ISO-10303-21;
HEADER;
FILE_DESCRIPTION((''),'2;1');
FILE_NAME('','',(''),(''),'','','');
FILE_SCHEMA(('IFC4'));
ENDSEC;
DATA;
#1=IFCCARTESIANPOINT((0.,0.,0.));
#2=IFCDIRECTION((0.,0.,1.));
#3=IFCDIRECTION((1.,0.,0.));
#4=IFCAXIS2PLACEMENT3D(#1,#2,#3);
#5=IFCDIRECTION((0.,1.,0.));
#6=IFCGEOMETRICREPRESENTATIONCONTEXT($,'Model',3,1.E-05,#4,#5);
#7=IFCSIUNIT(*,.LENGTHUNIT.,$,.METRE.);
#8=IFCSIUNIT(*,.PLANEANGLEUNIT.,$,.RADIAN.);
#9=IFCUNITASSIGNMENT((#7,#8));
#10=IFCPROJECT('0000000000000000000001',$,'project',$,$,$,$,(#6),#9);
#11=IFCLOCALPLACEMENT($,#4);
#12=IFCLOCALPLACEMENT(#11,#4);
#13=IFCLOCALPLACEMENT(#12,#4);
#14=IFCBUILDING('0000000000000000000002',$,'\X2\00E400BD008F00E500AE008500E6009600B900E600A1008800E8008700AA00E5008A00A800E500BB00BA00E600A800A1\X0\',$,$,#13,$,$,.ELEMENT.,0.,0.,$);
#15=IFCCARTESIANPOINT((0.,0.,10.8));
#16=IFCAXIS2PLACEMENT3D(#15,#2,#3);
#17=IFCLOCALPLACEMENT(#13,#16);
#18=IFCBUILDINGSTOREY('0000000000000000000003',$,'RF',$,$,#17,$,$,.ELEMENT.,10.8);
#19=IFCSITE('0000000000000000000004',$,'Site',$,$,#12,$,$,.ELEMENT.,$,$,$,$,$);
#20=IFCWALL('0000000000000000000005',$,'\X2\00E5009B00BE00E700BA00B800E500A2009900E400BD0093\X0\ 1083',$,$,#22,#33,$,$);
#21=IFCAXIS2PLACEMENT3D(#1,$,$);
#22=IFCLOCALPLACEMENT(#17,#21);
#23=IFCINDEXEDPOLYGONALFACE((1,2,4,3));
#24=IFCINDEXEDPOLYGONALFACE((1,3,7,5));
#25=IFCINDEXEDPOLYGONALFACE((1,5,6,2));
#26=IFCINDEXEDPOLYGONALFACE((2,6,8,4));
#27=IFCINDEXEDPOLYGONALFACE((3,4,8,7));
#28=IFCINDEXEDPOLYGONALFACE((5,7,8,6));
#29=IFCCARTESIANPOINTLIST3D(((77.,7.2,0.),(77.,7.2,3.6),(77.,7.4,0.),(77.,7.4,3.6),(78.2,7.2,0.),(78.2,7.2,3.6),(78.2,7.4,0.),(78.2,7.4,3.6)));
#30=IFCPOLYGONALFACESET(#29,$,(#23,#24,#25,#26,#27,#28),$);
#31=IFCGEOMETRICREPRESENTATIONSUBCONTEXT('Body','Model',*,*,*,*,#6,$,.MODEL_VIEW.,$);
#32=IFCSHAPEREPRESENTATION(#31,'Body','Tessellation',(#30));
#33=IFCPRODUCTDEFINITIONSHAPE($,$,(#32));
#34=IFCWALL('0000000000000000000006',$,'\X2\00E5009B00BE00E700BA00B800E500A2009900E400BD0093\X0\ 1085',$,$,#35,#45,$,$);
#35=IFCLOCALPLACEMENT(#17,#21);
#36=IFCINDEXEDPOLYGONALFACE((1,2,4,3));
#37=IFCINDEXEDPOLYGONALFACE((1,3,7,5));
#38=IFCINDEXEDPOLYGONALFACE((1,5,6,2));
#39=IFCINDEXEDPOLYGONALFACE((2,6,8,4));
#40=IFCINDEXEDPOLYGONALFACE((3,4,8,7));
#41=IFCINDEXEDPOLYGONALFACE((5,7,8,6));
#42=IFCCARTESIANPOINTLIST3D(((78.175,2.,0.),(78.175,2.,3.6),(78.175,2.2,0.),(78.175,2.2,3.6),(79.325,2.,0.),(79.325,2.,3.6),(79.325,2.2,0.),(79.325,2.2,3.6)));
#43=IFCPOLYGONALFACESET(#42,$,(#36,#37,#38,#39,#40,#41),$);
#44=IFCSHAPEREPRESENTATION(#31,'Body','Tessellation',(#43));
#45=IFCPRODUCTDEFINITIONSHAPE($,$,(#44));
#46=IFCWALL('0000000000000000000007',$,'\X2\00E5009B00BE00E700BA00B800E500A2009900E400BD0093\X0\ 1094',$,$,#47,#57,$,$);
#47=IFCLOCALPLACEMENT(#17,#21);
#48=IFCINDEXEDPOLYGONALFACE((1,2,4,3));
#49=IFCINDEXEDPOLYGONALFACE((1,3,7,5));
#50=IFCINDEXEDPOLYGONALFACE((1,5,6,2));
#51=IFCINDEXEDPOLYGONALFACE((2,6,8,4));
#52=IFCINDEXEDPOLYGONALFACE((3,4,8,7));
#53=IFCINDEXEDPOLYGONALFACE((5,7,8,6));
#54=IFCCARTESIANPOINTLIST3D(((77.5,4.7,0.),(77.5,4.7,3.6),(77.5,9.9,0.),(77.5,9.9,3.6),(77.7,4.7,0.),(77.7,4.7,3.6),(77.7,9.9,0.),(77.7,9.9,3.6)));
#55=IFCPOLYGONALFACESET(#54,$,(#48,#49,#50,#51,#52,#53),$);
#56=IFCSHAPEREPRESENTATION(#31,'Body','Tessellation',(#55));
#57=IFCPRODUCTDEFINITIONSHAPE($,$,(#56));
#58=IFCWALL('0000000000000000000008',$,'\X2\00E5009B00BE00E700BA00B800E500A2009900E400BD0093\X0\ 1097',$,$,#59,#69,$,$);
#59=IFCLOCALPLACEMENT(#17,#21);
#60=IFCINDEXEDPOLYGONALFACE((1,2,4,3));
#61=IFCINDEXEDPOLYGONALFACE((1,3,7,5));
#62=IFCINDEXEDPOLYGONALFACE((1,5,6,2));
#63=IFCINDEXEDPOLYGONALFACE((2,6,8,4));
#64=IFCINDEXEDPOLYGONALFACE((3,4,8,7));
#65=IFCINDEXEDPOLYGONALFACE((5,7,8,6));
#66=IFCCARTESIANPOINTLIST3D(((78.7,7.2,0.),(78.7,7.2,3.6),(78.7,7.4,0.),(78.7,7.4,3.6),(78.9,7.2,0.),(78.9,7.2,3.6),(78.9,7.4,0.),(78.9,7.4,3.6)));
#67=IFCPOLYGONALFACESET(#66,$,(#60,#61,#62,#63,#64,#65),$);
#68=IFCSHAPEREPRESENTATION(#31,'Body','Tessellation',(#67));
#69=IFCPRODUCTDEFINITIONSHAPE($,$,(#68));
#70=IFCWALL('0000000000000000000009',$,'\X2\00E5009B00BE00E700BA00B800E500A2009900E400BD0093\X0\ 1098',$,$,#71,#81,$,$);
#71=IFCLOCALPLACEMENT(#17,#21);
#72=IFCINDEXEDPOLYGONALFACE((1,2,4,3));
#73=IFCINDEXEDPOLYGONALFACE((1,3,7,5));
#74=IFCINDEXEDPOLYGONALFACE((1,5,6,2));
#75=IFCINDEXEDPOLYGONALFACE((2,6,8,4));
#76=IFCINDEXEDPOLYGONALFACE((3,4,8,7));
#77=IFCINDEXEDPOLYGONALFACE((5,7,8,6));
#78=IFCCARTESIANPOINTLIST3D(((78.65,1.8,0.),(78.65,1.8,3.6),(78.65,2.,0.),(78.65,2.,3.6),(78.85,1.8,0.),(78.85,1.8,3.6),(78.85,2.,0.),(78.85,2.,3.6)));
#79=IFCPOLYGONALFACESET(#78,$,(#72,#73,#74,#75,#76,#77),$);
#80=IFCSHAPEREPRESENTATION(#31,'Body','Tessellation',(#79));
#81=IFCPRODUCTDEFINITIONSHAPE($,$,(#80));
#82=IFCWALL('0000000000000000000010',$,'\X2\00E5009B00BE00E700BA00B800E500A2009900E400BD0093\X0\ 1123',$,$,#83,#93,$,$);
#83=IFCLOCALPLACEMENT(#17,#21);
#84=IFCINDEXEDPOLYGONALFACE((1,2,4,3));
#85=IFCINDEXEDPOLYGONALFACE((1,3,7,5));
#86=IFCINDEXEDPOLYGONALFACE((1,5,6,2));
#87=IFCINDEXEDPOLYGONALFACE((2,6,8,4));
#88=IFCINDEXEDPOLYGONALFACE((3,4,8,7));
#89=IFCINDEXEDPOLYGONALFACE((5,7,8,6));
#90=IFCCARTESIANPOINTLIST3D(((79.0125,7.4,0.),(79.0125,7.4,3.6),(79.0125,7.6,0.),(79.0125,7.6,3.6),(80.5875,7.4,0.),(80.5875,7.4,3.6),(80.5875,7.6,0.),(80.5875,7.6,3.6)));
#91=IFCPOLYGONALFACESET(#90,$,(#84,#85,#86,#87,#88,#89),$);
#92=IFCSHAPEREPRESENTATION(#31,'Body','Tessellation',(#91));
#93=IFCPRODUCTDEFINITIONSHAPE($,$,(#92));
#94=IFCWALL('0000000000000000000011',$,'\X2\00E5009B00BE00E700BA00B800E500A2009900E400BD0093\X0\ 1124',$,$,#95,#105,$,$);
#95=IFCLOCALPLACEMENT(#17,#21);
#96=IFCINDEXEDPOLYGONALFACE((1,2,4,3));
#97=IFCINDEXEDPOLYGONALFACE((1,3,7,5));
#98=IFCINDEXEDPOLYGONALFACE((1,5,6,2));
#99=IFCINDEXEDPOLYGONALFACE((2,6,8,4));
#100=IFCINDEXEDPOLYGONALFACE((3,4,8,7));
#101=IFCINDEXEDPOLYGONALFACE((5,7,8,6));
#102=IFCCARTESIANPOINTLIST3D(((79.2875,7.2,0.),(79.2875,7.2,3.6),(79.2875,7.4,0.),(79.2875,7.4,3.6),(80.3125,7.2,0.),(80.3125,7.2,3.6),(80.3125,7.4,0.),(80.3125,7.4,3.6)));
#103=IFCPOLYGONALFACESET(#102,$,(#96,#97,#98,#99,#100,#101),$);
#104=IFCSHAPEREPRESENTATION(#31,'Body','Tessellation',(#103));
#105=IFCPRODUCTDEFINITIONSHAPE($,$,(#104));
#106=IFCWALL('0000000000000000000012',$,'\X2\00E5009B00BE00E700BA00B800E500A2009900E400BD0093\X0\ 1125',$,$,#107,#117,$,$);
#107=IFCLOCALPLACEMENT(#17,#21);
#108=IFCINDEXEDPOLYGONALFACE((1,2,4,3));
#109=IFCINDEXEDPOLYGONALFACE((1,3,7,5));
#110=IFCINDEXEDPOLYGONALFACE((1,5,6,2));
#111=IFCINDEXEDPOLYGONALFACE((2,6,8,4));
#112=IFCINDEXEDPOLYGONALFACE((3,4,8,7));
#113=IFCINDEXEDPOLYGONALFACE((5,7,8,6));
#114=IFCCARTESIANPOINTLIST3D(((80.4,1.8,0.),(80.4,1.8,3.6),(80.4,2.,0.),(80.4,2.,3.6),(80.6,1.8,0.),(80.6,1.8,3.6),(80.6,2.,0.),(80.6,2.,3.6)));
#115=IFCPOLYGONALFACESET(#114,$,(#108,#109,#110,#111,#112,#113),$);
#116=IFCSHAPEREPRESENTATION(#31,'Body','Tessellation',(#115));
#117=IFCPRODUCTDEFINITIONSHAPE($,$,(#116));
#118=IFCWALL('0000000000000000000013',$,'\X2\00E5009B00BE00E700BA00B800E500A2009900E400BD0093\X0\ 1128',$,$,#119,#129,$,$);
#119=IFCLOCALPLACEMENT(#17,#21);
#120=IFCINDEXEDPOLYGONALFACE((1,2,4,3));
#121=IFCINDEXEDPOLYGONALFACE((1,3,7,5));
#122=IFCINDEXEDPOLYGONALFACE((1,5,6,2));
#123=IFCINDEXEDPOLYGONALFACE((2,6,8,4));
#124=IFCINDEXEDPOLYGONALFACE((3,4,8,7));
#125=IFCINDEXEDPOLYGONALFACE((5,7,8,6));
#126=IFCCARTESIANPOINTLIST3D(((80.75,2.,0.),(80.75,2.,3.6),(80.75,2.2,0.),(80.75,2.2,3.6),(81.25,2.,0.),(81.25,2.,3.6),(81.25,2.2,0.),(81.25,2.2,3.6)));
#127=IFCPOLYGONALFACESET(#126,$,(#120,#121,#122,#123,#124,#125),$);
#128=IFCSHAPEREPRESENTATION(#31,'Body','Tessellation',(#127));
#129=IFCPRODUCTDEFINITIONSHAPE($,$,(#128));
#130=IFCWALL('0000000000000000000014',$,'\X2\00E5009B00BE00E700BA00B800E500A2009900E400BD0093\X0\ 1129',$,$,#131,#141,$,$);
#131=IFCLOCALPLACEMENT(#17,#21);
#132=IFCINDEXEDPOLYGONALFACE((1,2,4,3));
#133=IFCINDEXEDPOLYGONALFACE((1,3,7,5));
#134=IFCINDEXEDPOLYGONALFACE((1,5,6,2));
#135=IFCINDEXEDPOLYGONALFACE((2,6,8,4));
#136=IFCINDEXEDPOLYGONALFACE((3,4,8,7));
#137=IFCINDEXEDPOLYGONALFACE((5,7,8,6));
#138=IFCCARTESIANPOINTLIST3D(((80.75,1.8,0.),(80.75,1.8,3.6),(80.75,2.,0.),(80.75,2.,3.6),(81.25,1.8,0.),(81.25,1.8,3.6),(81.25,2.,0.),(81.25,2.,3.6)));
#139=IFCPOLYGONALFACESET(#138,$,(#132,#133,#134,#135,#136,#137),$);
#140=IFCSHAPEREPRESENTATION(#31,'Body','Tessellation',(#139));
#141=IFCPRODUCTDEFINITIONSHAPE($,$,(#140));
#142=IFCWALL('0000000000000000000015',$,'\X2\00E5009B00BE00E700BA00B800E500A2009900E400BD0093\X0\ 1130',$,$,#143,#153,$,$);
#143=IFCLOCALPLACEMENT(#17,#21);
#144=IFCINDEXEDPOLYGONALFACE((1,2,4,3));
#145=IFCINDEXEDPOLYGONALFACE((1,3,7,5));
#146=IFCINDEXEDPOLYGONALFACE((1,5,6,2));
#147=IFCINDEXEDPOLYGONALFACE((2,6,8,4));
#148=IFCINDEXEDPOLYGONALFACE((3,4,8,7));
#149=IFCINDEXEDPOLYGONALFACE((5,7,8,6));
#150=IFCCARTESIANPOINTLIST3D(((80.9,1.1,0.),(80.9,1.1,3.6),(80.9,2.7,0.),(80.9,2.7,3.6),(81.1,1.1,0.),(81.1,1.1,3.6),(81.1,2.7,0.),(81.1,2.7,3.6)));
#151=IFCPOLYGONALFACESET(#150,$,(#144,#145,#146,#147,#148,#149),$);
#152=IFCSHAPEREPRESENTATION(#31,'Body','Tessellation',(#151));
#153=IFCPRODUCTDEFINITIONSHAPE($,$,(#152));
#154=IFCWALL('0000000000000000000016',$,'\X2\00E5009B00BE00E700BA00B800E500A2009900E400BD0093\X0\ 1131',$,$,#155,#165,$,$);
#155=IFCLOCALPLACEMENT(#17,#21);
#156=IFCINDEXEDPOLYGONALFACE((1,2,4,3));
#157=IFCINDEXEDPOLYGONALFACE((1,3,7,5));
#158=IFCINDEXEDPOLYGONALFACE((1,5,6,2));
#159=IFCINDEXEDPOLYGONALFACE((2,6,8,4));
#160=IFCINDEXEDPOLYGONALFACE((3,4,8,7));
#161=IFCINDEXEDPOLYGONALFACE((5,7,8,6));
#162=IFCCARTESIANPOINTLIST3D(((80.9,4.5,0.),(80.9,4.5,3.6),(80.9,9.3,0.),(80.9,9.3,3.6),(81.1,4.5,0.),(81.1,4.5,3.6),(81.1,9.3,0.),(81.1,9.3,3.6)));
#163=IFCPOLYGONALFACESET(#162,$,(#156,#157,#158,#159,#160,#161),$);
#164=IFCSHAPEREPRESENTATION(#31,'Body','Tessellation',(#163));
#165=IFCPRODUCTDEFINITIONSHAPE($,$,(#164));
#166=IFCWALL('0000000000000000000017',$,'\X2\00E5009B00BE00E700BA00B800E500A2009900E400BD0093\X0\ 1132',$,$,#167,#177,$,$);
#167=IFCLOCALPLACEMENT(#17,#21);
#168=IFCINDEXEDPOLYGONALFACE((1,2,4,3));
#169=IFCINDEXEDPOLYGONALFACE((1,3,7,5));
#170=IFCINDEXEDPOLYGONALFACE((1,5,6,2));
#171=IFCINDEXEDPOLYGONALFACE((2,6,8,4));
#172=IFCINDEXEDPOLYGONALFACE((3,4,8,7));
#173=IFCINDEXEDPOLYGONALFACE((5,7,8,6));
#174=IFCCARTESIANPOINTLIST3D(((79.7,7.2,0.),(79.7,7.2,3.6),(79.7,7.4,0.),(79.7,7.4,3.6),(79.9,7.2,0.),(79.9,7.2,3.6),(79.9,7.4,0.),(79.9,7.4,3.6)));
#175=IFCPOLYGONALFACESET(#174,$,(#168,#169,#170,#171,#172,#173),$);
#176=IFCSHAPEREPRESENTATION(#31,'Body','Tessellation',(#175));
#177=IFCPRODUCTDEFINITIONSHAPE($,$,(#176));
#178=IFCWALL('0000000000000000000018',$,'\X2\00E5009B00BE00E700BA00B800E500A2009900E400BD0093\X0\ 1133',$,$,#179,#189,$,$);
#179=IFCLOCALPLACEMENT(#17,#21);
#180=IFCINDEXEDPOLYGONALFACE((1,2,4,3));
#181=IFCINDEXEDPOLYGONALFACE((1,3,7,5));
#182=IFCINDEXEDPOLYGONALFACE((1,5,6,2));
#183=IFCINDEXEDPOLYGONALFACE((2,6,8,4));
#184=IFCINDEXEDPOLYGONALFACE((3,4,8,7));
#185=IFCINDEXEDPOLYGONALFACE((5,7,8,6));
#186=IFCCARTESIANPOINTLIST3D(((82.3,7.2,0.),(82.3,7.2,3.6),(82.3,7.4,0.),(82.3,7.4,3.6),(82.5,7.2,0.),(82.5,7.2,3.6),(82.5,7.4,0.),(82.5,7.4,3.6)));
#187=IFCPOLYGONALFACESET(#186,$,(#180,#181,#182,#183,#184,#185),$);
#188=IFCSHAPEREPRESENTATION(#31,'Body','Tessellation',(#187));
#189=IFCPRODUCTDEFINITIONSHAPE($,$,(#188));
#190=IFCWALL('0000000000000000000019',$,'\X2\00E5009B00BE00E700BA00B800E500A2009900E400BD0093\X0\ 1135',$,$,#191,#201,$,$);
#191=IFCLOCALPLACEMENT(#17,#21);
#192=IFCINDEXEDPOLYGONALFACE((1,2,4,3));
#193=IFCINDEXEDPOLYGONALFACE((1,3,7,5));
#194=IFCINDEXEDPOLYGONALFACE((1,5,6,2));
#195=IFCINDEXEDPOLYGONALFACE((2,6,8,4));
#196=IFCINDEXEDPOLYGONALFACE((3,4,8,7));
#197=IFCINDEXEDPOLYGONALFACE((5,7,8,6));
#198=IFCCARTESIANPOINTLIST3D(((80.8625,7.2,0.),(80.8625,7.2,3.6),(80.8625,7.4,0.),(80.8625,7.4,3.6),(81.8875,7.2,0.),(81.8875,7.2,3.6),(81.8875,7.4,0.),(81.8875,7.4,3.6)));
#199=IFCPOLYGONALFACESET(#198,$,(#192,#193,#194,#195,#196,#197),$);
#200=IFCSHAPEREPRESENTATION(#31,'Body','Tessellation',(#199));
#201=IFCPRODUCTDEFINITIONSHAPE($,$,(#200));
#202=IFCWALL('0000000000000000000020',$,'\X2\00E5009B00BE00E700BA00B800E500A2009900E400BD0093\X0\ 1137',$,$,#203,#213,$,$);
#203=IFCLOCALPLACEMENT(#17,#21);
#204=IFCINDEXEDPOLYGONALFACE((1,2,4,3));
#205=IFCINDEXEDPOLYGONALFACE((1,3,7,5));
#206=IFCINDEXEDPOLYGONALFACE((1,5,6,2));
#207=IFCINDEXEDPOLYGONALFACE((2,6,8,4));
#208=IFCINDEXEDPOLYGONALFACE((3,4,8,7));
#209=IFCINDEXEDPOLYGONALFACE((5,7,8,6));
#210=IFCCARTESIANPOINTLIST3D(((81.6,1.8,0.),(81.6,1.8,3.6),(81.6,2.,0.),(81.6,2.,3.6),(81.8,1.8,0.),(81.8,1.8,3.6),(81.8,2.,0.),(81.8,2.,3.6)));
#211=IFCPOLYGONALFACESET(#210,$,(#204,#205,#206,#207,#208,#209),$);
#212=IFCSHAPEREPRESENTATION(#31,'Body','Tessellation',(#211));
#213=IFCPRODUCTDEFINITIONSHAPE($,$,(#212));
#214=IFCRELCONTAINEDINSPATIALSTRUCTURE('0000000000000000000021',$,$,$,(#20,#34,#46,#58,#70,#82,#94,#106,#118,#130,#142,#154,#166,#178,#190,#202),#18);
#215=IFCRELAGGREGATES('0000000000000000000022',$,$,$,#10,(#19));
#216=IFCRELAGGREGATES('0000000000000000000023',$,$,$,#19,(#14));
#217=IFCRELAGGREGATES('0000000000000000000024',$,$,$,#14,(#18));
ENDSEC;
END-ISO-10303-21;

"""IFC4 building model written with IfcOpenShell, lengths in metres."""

from ifc_helpers import new_model, si_unit, direction, frame, frame_2d, origin_with_axes, place, context, subcontext, project, spatial, rectangle, extrude, element, save


model = new_model("IFC4")

# Units and contexts
model_context = context("Model", 3, precision=1e-05, world=origin_with_axes(), true_north=direction((0.0, 1.0, 0.0)))
body_context = subcontext(model_context, "Body", "Model", "MODEL_VIEW")
ifc_project = project(units=[si_unit("LENGTHUNIT", "METRE"), si_unit("PLANEANGLEUNIT", "RADIAN")], contexts=[model_context])

# Site, building, storey
placement = place(None, origin_with_axes())
site_placement = place(placement, origin_with_axes())
site = spatial("IfcSite", under=ifc_project, at=site_placement, Name="Site", CompositionType="ELEMENT")
building_placement = place(site_placement, origin_with_axes())
building = spatial("IfcBuilding", under=site, at=building_placement, Name="ä½\u008få®\u0085æ\u0096¹æ¡\u0088è\u0087ªå\u008a¨å»ºæ¨¡", CompositionType="ELEMENT", ElevationOfRefHeight=0.0, ElevationOfTerrain=0.0)
storey_placement = place(building_placement, frame((0.0, 0.0, 10.8), z_axis=(0.0, 0.0, 1.0), x_axis=(1.0, 0.0, 0.0)))
storey = spatial("IfcBuildingStorey", under=building, at=storey_placement, Name="RF", CompositionType="ELEMENT", Elevation=10.8)

# Walls
wall_1_placement = place(storey_placement, frame((77.6, 7.3, 0.0), z_axis=(0.0, 0.0, 1.0), x_axis=(1.0, 0.0, 0.0)))
element("IfcWall", 1, at=wall_1_placement, inside=storey, Name="å\u009b¾çº¸å¢\u0099ä½\u0093 1083", context=body_context, shape_type="SweptSolid", body=[
    extrude(rectangle(XDim=1.2, YDim=0.2, at=frame_2d((0.0, 0.0), x_axis=(1.0, 0.0, 0.0))), frame((0.0, 0.0, 0.0), z_axis=(0.0, 0.0, 1.0)), (0.0, 0.0, 1.0), 3.6),
])
wall_2_placement = place(storey_placement, frame((78.75, 2.1, 0.0), z_axis=(0.0, 0.0, 1.0), x_axis=(-1.0, 0.0, 0.0)))
element("IfcWall", 2, at=wall_2_placement, inside=storey, Name="å\u009b¾çº¸å¢\u0099ä½\u0093 1085", context=body_context, shape_type="SweptSolid", body=[
    extrude(rectangle(XDim=1.15, YDim=0.2, at=frame_2d((0.0, 0.0), x_axis=(1.0, 0.0, 0.0))), frame((0.0, 0.0, 0.0), z_axis=(0.0, 0.0, 1.0)), (0.0, 0.0, 1.0), 3.6),
])
wall_3_placement = place(storey_placement, frame((77.6, 7.3, 0.0), z_axis=(0.0, 0.0, 1.0), x_axis=(0.0, -1.0, 0.0)))
element("IfcWall", 3, at=wall_3_placement, inside=storey, Name="å\u009b¾çº¸å¢\u0099ä½\u0093 1094", context=body_context, shape_type="SweptSolid", body=[
    extrude(rectangle(XDim=5.2, YDim=0.2, at=frame_2d((0.0, 0.0), x_axis=(1.0, 0.0, 0.0))), frame((0.0, 0.0, 0.0), z_axis=(0.0, 0.0, 1.0)), (0.0, 0.0, 1.0), 3.6),
])
for number, where, z_axis, x_axis, name in (
    (4, (78.8, 7.3, 0.0), (0.0, 0.0, 1.0), (0.0, 1.0, 0.0), "å\u009b¾çº¸å¢\u0099ä½\u0093 1097"),
    (5, (78.75, 1.9, 0.0), (0.0, 0.0, 1.0), (0.0, 1.0, 0.0), "å\u009b¾çº¸å¢\u0099ä½\u0093 1098"),
):
    element("IfcWall", number, at=place(storey_placement, frame(where, z_axis=z_axis, x_axis=x_axis)), inside=storey, Name=name, context=body_context, shape_type="SweptSolid", body=[
        extrude(rectangle(XDim=0.2, YDim=0.2, at=frame_2d((0.0, 0.0), x_axis=(1.0, 0.0, 0.0))), frame((0.0, 0.0, 0.0), z_axis=(0.0, 0.0, 1.0)), (0.0, 0.0, 1.0), 3.6),
    ])
wall_4_placement = place(storey_placement, frame((79.8, 7.5, 0.0), z_axis=(0.0, 0.0, 1.0), x_axis=(1.0, 0.0, 0.0)))
element("IfcWall", 6, at=wall_4_placement, inside=storey, Name="å\u009b¾çº¸å¢\u0099ä½\u0093 1123", context=body_context, shape_type="SweptSolid", body=[
    extrude(rectangle(XDim=1.575, YDim=0.2, at=frame_2d((0.0, 0.0), x_axis=(1.0, 0.0, 0.0))), frame((0.0, 0.0, 0.0), z_axis=(0.0, 0.0, 1.0)), (0.0, 0.0, 1.0), 3.6),
])
wall_5_placement = place(storey_placement, frame((79.8, 7.3, 0.0), z_axis=(0.0, 0.0, 1.0), x_axis=(1.0, 0.0, 0.0)))
element("IfcWall", 7, at=wall_5_placement, inside=storey, Name="å\u009b¾çº¸å¢\u0099ä½\u0093 1124", context=body_context, shape_type="SweptSolid", body=[
    extrude(rectangle(XDim=1.025, YDim=0.2, at=frame_2d((0.0, 0.0), x_axis=(1.0, 0.0, 0.0))), frame((0.0, 0.0, 0.0), z_axis=(0.0, 0.0, 1.0)), (0.0, 0.0, 1.0), 3.6),
])
wall_6_placement = place(storey_placement, frame((80.5, 1.9, 0.0), z_axis=(0.0, 0.0, 1.0), x_axis=(0.0, 1.0, 0.0)))
element("IfcWall", 8, at=wall_6_placement, inside=storey, Name="å\u009b¾çº¸å¢\u0099ä½\u0093 1125", context=body_context, shape_type="SweptSolid", body=[
    extrude(rectangle(XDim=0.2, YDim=0.2, at=frame_2d((0.0, 0.0), x_axis=(1.0, 0.0, 0.0))), frame((0.0, 0.0, 0.0), z_axis=(0.0, 0.0, 1.0)), (0.0, 0.0, 1.0), 3.6),
])
for number, where, z_axis, x_axis, name in (
    (9, (81.0, 2.1, 0.0), (0.0, 0.0, 1.0), (-1.0, 0.0, 0.0), "å\u009b¾çº¸å¢\u0099ä½\u0093 1128"),
    (10, (81.0, 1.9, 0.0), (0.0, 0.0, 1.0), (-1.0, 0.0, 0.0), "å\u009b¾çº¸å¢\u0099ä½\u0093 1129"),
):
    element("IfcWall", number, at=place(storey_placement, frame(where, z_axis=z_axis, x_axis=x_axis)), inside=storey, Name=name, context=body_context, shape_type="SweptSolid", body=[
        extrude(rectangle(XDim=0.5, YDim=0.2, at=frame_2d((0.0, 0.0), x_axis=(1.0, 0.0, 0.0))), frame((0.0, 0.0, 0.0), z_axis=(0.0, 0.0, 1.0)), (0.0, 0.0, 1.0), 3.6),
    ])
wall_7_placement = place(storey_placement, frame((81.0, 1.9, 0.0), z_axis=(0.0, 0.0, 1.0), x_axis=(0.0, -1.0, 0.0)))
element("IfcWall", 11, at=wall_7_placement, inside=storey, Name="å\u009b¾çº¸å¢\u0099ä½\u0093 1130", context=body_context, shape_type="SweptSolid", body=[
    extrude(rectangle(XDim=1.6, YDim=0.2, at=frame_2d((0.0, 0.0), x_axis=(1.0, 0.0, 0.0))), frame((0.0, 0.0, 0.0), z_axis=(0.0, 0.0, 1.0)), (0.0, 0.0, 1.0), 3.6),
])
wall_8_placement = place(storey_placement, frame((81.0, 6.9, 0.0), z_axis=(0.0, 0.0, 1.0), x_axis=(0.0, -1.0, 0.0)))
element("IfcWall", 12, at=wall_8_placement, inside=storey, Name="å\u009b¾çº¸å¢\u0099ä½\u0093 1131", context=body_context, shape_type="SweptSolid", body=[
    extrude(rectangle(XDim=4.8, YDim=0.2, at=frame_2d((0.0, 0.0), x_axis=(1.0, 0.0, 0.0))), frame((0.0, 0.0, 0.0), z_axis=(0.0, 0.0, 1.0)), (0.0, 0.0, 1.0), 3.6),
])
for number, where, z_axis, x_axis, name in (
    (13, (79.8, 7.3, 0.0), (0.0, 0.0, 1.0), (0.0, 1.0, 0.0), "å\u009b¾çº¸å¢\u0099ä½\u0093 1132"),
    (14, (82.4, 7.3, 0.0), (0.0, 0.0, 1.0), (0.0, 1.0, 0.0), "å\u009b¾çº¸å¢\u0099ä½\u0093 1133"),
):
    element("IfcWall", number, at=place(storey_placement, frame(where, z_axis=z_axis, x_axis=x_axis)), inside=storey, Name=name, context=body_context, shape_type="SweptSolid", body=[
        extrude(rectangle(XDim=0.2, YDim=0.2, at=frame_2d((0.0, 0.0), x_axis=(1.0, 0.0, 0.0))), frame((0.0, 0.0, 0.0), z_axis=(0.0, 0.0, 1.0)), (0.0, 0.0, 1.0), 3.6),
    ])
wall_9_placement = place(storey_placement, frame((81.375, 7.3, 0.0), z_axis=(0.0, 0.0, 1.0), x_axis=(1.0, 0.0, 0.0)))
element("IfcWall", 15, at=wall_9_placement, inside=storey, Name="å\u009b¾çº¸å¢\u0099ä½\u0093 1135", context=body_context, shape_type="SweptSolid", body=[
    extrude(rectangle(XDim=1.025, YDim=0.2, at=frame_2d((0.0, 0.0), x_axis=(1.0, 0.0, 0.0))), frame((0.0, 0.0, 0.0), z_axis=(0.0, 0.0, 1.0)), (0.0, 0.0, 1.0), 3.6),
])
wall_10_placement = place(storey_placement, frame((81.7, 1.9, 0.0), z_axis=(0.0, 0.0, 1.0), x_axis=(0.0, 1.0, 0.0)))
element("IfcWall", 16, at=wall_10_placement, inside=storey, Name="å\u009b¾çº¸å¢\u0099ä½\u0093 1137", context=body_context, shape_type="SweptSolid", body=[
    extrude(rectangle(XDim=0.2, YDim=0.2, at=frame_2d((0.0, 0.0), x_axis=(1.0, 0.0, 0.0))), frame((0.0, 0.0, 0.0), z_axis=(0.0, 0.0, 1.0)), (0.0, 0.0, 1.0), 3.6),
])

save(model, "model.ifc")
